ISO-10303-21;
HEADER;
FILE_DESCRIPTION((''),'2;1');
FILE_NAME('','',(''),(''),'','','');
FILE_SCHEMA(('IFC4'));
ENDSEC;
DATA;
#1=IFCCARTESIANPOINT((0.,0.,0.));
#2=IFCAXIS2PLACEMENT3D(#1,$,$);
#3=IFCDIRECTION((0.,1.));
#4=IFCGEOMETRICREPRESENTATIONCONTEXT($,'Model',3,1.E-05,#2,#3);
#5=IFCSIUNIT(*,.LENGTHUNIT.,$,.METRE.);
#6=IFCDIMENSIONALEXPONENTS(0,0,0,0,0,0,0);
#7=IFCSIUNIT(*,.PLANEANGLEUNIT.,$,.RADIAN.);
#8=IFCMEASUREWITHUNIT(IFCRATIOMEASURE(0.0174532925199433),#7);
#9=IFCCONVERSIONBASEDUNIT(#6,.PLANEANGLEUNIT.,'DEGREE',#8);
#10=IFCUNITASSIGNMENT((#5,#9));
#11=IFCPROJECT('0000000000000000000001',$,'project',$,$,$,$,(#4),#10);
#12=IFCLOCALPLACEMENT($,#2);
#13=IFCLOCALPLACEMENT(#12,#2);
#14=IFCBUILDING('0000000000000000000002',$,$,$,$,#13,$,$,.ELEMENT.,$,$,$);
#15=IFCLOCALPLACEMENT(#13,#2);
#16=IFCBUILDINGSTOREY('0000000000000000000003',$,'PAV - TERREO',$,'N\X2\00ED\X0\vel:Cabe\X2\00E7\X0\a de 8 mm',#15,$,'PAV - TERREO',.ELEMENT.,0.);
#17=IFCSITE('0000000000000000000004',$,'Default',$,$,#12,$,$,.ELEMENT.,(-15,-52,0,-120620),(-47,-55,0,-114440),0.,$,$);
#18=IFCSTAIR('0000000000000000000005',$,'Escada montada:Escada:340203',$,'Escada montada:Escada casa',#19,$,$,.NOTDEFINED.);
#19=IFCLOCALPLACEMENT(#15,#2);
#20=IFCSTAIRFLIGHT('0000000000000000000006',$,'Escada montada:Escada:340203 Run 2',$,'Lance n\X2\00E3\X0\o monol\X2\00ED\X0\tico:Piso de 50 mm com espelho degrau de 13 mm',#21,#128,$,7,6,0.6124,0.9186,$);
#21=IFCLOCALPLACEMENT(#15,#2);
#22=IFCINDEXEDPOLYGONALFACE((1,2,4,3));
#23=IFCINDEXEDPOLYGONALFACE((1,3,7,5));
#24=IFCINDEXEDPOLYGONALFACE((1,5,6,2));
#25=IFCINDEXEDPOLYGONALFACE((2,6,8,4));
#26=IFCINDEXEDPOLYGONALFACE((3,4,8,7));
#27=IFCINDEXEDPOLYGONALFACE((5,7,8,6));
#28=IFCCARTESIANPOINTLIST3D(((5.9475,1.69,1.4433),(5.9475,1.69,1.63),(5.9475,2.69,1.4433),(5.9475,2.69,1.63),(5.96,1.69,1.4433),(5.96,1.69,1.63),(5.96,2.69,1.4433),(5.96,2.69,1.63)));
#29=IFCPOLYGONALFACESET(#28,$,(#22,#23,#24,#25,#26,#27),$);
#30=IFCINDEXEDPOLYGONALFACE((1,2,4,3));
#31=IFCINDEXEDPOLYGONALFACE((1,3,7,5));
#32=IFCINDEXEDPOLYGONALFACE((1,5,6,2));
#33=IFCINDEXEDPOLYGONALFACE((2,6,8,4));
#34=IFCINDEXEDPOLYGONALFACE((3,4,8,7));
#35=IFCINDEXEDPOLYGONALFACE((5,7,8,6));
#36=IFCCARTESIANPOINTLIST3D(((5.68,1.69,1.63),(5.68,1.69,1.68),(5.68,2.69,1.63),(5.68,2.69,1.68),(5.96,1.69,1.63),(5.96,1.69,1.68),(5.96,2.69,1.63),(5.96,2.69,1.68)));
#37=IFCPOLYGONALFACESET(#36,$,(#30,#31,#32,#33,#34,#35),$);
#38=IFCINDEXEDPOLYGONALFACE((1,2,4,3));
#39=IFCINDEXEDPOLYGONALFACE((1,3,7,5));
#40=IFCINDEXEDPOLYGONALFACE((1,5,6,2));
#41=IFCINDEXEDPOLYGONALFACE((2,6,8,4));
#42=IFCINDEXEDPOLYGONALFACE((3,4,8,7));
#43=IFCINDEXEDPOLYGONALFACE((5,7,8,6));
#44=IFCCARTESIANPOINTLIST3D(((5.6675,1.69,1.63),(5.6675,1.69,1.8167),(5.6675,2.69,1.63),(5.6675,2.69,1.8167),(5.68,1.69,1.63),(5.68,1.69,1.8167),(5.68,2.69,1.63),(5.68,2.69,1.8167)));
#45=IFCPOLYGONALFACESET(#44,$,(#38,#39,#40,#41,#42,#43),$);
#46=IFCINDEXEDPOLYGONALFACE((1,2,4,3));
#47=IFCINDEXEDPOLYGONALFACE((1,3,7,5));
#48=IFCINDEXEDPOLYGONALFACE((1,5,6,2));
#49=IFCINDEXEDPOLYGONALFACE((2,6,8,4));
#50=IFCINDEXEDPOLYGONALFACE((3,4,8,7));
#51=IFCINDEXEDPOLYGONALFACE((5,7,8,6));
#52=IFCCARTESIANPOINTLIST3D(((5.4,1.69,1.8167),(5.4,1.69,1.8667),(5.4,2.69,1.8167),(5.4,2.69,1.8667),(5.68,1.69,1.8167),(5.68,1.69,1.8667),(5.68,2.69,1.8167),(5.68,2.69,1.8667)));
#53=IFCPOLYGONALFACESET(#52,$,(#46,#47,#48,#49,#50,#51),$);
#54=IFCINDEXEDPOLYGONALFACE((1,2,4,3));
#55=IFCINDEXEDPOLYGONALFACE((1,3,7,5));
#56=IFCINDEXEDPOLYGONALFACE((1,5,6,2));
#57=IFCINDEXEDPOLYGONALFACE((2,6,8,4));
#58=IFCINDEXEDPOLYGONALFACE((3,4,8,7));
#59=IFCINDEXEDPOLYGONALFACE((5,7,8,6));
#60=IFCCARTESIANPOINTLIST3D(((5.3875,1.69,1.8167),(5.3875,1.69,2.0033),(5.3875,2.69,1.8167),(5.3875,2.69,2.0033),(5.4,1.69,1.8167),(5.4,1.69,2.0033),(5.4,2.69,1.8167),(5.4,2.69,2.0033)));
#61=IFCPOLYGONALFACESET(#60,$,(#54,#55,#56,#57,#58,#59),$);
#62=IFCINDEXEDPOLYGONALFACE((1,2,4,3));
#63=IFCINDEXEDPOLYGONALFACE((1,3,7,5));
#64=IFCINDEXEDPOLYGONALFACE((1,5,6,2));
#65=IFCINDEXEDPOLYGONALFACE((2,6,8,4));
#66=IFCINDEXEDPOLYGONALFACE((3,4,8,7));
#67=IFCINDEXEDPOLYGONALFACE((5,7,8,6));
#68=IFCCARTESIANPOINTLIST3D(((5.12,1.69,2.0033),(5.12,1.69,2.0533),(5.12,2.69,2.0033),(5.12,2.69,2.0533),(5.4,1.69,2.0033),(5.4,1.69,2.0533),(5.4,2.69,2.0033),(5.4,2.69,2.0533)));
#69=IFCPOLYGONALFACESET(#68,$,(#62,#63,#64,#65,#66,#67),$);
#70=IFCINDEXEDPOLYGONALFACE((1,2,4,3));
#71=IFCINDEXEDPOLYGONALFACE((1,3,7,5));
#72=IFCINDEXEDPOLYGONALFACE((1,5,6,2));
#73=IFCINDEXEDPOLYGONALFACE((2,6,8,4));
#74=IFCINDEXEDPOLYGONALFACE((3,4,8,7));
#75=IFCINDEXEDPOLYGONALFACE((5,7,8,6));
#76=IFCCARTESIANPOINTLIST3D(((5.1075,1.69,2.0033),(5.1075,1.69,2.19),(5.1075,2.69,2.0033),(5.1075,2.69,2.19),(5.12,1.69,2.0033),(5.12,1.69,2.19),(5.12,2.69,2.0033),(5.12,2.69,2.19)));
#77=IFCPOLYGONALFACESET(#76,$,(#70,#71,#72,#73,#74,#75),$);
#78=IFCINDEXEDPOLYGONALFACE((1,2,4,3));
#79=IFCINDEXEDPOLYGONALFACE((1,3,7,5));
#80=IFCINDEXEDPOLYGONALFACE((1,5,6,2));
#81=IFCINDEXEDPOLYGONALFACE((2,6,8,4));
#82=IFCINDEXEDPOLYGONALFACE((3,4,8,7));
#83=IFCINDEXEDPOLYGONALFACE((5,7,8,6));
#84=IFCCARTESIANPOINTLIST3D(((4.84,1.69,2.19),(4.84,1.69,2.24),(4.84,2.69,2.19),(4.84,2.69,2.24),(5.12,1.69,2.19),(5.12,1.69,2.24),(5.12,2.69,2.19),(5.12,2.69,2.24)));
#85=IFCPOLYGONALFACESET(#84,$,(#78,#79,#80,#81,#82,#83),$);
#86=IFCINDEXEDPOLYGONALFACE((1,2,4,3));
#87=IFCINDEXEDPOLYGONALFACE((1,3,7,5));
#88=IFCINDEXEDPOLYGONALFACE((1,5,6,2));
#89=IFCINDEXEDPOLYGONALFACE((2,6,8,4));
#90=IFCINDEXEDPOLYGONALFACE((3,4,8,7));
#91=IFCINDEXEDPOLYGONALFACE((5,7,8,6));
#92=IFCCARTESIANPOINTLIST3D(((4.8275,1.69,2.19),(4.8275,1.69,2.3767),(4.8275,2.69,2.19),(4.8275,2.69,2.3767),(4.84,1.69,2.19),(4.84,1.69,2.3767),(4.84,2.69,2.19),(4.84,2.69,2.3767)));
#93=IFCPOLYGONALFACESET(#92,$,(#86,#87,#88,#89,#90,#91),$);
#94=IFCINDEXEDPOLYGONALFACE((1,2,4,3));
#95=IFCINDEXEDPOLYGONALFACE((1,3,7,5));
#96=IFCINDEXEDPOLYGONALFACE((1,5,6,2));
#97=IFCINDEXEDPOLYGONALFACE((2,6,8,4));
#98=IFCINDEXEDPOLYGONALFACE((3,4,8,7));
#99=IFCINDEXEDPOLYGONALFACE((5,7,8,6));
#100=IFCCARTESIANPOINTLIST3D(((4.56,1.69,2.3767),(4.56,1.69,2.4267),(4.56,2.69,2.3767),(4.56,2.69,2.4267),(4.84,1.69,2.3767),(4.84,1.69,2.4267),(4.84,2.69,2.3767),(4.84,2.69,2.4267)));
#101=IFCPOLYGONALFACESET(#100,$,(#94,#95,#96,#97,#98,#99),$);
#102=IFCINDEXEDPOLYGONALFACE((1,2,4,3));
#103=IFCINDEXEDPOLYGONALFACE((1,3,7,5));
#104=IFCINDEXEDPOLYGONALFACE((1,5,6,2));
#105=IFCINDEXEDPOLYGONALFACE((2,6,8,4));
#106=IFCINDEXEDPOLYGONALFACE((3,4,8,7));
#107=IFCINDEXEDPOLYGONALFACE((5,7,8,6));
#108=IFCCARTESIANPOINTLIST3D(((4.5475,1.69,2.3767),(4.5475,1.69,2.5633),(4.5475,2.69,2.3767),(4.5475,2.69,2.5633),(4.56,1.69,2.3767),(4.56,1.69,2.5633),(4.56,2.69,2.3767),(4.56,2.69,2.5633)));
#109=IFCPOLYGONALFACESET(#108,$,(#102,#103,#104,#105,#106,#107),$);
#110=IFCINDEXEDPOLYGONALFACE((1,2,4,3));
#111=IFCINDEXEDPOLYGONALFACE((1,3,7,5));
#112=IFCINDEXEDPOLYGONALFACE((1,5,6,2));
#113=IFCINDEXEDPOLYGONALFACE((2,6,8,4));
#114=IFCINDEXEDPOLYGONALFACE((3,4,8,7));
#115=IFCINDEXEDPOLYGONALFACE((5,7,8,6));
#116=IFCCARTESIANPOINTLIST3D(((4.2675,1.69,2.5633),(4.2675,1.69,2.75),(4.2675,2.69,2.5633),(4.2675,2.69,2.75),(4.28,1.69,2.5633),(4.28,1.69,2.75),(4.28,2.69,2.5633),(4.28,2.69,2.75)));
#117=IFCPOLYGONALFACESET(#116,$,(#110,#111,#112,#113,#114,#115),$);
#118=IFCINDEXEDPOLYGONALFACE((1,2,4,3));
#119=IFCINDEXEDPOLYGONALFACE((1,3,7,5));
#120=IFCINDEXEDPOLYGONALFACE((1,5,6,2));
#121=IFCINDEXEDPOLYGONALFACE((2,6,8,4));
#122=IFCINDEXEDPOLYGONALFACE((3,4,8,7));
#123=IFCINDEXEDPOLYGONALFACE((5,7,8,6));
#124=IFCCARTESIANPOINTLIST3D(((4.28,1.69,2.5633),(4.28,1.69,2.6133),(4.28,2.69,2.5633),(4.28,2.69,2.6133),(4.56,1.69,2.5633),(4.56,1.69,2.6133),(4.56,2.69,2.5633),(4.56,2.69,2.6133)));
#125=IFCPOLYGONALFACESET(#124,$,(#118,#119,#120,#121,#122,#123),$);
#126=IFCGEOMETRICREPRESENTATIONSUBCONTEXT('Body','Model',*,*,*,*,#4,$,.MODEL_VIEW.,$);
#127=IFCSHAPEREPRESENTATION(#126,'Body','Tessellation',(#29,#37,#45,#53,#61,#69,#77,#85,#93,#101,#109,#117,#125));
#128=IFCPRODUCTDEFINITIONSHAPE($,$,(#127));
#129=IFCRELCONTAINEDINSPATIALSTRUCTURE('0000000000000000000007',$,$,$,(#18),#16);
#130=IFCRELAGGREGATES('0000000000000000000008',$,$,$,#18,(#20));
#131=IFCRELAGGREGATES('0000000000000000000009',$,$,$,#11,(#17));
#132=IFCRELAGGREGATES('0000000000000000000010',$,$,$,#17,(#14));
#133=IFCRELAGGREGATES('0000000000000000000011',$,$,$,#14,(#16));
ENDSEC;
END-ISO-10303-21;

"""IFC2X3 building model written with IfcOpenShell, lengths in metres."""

from ifc_helpers import new_model, entity, si_unit, converted_unit, direction, frame, frame_2d, origin, origin_2d_with_axis, place, context, subcontext, project, spatial, rectangle, extrude, element, aggregate, save


model = new_model("IFC2X3")

# Units and contexts
model_context = context("Model", 3, precision=1e-05, world=origin(), true_north=direction((0.0, 1.0)))
body_context = subcontext(model_context, "Body", "Model", "MODEL_VIEW")
ifc_project = project(units=[si_unit("LENGTHUNIT", "METRE"), converted_unit("PLANEANGLEUNIT", "DEGREE", entity("IfcRatioMeasure", 0.0174532925199433), si_unit("PLANEANGLEUNIT", "RADIAN"), dimensions=[0, 0, 0, 0, 0, 0, 0])], contexts=[model_context])

# Site, building, storey
site_placement = place(None, origin())
site = spatial("IfcSite", under=ifc_project, at=site_placement, Name="Default", CompositionType="ELEMENT", RefLatitude=(-15, -52, 0, -120620), RefLongitude=(-47, -55, 0, -114440), RefElevation=0.0)
building_placement = place(site_placement, origin())
building = spatial("IfcBuilding", under=site, at=building_placement, CompositionType="ELEMENT")
storey_placement = place(building_placement, origin())
storey = spatial("IfcBuildingStorey", under=building, at=storey_placement, Name="PAV - TERREO", ObjectType="Nível:Cabeça de 8 mm", LongName="PAV - TERREO", CompositionType="ELEMENT", Elevation=0.0)

# Stair
stair_placement = place(storey_placement, origin())
stair = element("IfcStair", 1, at=stair_placement, inside=storey, Name="Escada montada:Escada:340203", ObjectType="Escada montada:Escada casa", ShapeType="NOTDEFINED")

# Stair flight
stair_flight_1_placement = place(stair_placement, origin())
stair_flight_1 = element("IfcStairFlight", 2, at=stair_flight_1_placement, Name="Escada montada:Escada:340203 Run 2", ObjectType="Lance não monolítico:Piso de 50 mm com espelho degrau de 13 mm", NumberOfRiser=7, NumberOfTreads=6, RiserHeight=0.6124, TreadLength=0.9186, context=body_context, shape_type="SweptSolid", body=[
    extrude(rectangle(XDim=1.0, YDim=0.0125, at=frame_2d((0.0, 0.0), x_axis=(1.0, 0.0))), frame((5.9538, 2.19, 1.4433), z_axis=(0.0, 0.0, 1.0), x_axis=(0.0, -1.0, 0.0)), (0.0, 0.0, 1.0), 0.1867),
    extrude(rectangle(XDim=0.28, YDim=1.0, at=frame_2d((0.0, 0.0), x_axis=(1.0, 0.0))), frame((5.82, 2.19, 1.63)), (0.0, 0.0, 1.0), 0.05),
    extrude(rectangle(XDim=1.0, YDim=0.0125, at=frame_2d((0.0, 0.0), x_axis=(1.0, 0.0))), frame((5.6738, 2.19, 1.63), z_axis=(0.0, 0.0, 1.0), x_axis=(0.0, -1.0, 0.0)), (0.0, 0.0, 1.0), 0.1867),
    extrude(rectangle(XDim=0.28, YDim=1.0, at=frame_2d((0.0, 0.0), x_axis=(1.0, 0.0))), frame((5.54, 2.19, 1.8167)), (0.0, 0.0, 1.0), 0.05),
    extrude(rectangle(XDim=1.0, YDim=0.0125, at=frame_2d((0.0, 0.0), x_axis=(1.0, 0.0))), frame((5.3938, 2.19, 1.8167), z_axis=(0.0, 0.0, 1.0), x_axis=(0.0, -1.0, 0.0)), (0.0, 0.0, 1.0), 0.1867),
    extrude(rectangle(XDim=0.28, YDim=1.0, at=frame_2d((0.0, 0.0), x_axis=(1.0, 0.0))), frame((5.26, 2.19, 2.0033)), (0.0, 0.0, 1.0), 0.05),
    extrude(rectangle(XDim=1.0, YDim=0.0125, at=frame_2d((0.0, 0.0), x_axis=(1.0, 0.0))), frame((5.1138, 2.19, 2.0033), z_axis=(0.0, 0.0, 1.0), x_axis=(0.0, -1.0, 0.0)), (0.0, 0.0, 1.0), 0.1867),
    extrude(rectangle(XDim=0.28, YDim=1.0, at=frame_2d((0.0, 0.0), x_axis=(1.0, 0.0))), frame((4.98, 2.19, 2.19)), (0.0, 0.0, 1.0), 0.05),
    extrude(rectangle(XDim=1.0, YDim=0.0125, at=frame_2d((0.0, 0.0), x_axis=(1.0, 0.0))), frame((4.8338, 2.19, 2.19), z_axis=(0.0, 0.0, 1.0), x_axis=(0.0, -1.0, 0.0)), (0.0, 0.0, 1.0), 0.1867),
    extrude(rectangle(XDim=0.28, YDim=1.0, at=frame_2d((0.0, 0.0), x_axis=(1.0, 0.0))), frame((4.7, 2.19, 2.3767)), (0.0, 0.0, 1.0), 0.05),
    extrude(rectangle(XDim=1.0, YDim=0.0125, at=frame_2d((0.0, 0.0), x_axis=(1.0, 0.0))), frame((4.5538, 2.19, 2.3767), z_axis=(0.0, 0.0, 1.0), x_axis=(0.0, -1.0, 0.0)), (0.0, 0.0, 1.0), 0.1867),
    extrude(rectangle(XDim=1.0, YDim=0.0125, at=origin_2d_with_axis()), frame((4.2738, 2.19, 2.5633), z_axis=(0.0, 0.0, 1.0), x_axis=(0.0, -1.0, 0.0)), (0.0, 0.0, 1.0), 0.1867),
    extrude(rectangle(XDim=0.28, YDim=1.0, at=frame_2d((0.0, 0.0), x_axis=(1.0, 0.0))), frame((4.42, 2.19, 2.5633)), (0.0, 0.0, 1.0), 0.05),
])
aggregate(stair, [stair_flight_1])

save(model, "model.ifc")
